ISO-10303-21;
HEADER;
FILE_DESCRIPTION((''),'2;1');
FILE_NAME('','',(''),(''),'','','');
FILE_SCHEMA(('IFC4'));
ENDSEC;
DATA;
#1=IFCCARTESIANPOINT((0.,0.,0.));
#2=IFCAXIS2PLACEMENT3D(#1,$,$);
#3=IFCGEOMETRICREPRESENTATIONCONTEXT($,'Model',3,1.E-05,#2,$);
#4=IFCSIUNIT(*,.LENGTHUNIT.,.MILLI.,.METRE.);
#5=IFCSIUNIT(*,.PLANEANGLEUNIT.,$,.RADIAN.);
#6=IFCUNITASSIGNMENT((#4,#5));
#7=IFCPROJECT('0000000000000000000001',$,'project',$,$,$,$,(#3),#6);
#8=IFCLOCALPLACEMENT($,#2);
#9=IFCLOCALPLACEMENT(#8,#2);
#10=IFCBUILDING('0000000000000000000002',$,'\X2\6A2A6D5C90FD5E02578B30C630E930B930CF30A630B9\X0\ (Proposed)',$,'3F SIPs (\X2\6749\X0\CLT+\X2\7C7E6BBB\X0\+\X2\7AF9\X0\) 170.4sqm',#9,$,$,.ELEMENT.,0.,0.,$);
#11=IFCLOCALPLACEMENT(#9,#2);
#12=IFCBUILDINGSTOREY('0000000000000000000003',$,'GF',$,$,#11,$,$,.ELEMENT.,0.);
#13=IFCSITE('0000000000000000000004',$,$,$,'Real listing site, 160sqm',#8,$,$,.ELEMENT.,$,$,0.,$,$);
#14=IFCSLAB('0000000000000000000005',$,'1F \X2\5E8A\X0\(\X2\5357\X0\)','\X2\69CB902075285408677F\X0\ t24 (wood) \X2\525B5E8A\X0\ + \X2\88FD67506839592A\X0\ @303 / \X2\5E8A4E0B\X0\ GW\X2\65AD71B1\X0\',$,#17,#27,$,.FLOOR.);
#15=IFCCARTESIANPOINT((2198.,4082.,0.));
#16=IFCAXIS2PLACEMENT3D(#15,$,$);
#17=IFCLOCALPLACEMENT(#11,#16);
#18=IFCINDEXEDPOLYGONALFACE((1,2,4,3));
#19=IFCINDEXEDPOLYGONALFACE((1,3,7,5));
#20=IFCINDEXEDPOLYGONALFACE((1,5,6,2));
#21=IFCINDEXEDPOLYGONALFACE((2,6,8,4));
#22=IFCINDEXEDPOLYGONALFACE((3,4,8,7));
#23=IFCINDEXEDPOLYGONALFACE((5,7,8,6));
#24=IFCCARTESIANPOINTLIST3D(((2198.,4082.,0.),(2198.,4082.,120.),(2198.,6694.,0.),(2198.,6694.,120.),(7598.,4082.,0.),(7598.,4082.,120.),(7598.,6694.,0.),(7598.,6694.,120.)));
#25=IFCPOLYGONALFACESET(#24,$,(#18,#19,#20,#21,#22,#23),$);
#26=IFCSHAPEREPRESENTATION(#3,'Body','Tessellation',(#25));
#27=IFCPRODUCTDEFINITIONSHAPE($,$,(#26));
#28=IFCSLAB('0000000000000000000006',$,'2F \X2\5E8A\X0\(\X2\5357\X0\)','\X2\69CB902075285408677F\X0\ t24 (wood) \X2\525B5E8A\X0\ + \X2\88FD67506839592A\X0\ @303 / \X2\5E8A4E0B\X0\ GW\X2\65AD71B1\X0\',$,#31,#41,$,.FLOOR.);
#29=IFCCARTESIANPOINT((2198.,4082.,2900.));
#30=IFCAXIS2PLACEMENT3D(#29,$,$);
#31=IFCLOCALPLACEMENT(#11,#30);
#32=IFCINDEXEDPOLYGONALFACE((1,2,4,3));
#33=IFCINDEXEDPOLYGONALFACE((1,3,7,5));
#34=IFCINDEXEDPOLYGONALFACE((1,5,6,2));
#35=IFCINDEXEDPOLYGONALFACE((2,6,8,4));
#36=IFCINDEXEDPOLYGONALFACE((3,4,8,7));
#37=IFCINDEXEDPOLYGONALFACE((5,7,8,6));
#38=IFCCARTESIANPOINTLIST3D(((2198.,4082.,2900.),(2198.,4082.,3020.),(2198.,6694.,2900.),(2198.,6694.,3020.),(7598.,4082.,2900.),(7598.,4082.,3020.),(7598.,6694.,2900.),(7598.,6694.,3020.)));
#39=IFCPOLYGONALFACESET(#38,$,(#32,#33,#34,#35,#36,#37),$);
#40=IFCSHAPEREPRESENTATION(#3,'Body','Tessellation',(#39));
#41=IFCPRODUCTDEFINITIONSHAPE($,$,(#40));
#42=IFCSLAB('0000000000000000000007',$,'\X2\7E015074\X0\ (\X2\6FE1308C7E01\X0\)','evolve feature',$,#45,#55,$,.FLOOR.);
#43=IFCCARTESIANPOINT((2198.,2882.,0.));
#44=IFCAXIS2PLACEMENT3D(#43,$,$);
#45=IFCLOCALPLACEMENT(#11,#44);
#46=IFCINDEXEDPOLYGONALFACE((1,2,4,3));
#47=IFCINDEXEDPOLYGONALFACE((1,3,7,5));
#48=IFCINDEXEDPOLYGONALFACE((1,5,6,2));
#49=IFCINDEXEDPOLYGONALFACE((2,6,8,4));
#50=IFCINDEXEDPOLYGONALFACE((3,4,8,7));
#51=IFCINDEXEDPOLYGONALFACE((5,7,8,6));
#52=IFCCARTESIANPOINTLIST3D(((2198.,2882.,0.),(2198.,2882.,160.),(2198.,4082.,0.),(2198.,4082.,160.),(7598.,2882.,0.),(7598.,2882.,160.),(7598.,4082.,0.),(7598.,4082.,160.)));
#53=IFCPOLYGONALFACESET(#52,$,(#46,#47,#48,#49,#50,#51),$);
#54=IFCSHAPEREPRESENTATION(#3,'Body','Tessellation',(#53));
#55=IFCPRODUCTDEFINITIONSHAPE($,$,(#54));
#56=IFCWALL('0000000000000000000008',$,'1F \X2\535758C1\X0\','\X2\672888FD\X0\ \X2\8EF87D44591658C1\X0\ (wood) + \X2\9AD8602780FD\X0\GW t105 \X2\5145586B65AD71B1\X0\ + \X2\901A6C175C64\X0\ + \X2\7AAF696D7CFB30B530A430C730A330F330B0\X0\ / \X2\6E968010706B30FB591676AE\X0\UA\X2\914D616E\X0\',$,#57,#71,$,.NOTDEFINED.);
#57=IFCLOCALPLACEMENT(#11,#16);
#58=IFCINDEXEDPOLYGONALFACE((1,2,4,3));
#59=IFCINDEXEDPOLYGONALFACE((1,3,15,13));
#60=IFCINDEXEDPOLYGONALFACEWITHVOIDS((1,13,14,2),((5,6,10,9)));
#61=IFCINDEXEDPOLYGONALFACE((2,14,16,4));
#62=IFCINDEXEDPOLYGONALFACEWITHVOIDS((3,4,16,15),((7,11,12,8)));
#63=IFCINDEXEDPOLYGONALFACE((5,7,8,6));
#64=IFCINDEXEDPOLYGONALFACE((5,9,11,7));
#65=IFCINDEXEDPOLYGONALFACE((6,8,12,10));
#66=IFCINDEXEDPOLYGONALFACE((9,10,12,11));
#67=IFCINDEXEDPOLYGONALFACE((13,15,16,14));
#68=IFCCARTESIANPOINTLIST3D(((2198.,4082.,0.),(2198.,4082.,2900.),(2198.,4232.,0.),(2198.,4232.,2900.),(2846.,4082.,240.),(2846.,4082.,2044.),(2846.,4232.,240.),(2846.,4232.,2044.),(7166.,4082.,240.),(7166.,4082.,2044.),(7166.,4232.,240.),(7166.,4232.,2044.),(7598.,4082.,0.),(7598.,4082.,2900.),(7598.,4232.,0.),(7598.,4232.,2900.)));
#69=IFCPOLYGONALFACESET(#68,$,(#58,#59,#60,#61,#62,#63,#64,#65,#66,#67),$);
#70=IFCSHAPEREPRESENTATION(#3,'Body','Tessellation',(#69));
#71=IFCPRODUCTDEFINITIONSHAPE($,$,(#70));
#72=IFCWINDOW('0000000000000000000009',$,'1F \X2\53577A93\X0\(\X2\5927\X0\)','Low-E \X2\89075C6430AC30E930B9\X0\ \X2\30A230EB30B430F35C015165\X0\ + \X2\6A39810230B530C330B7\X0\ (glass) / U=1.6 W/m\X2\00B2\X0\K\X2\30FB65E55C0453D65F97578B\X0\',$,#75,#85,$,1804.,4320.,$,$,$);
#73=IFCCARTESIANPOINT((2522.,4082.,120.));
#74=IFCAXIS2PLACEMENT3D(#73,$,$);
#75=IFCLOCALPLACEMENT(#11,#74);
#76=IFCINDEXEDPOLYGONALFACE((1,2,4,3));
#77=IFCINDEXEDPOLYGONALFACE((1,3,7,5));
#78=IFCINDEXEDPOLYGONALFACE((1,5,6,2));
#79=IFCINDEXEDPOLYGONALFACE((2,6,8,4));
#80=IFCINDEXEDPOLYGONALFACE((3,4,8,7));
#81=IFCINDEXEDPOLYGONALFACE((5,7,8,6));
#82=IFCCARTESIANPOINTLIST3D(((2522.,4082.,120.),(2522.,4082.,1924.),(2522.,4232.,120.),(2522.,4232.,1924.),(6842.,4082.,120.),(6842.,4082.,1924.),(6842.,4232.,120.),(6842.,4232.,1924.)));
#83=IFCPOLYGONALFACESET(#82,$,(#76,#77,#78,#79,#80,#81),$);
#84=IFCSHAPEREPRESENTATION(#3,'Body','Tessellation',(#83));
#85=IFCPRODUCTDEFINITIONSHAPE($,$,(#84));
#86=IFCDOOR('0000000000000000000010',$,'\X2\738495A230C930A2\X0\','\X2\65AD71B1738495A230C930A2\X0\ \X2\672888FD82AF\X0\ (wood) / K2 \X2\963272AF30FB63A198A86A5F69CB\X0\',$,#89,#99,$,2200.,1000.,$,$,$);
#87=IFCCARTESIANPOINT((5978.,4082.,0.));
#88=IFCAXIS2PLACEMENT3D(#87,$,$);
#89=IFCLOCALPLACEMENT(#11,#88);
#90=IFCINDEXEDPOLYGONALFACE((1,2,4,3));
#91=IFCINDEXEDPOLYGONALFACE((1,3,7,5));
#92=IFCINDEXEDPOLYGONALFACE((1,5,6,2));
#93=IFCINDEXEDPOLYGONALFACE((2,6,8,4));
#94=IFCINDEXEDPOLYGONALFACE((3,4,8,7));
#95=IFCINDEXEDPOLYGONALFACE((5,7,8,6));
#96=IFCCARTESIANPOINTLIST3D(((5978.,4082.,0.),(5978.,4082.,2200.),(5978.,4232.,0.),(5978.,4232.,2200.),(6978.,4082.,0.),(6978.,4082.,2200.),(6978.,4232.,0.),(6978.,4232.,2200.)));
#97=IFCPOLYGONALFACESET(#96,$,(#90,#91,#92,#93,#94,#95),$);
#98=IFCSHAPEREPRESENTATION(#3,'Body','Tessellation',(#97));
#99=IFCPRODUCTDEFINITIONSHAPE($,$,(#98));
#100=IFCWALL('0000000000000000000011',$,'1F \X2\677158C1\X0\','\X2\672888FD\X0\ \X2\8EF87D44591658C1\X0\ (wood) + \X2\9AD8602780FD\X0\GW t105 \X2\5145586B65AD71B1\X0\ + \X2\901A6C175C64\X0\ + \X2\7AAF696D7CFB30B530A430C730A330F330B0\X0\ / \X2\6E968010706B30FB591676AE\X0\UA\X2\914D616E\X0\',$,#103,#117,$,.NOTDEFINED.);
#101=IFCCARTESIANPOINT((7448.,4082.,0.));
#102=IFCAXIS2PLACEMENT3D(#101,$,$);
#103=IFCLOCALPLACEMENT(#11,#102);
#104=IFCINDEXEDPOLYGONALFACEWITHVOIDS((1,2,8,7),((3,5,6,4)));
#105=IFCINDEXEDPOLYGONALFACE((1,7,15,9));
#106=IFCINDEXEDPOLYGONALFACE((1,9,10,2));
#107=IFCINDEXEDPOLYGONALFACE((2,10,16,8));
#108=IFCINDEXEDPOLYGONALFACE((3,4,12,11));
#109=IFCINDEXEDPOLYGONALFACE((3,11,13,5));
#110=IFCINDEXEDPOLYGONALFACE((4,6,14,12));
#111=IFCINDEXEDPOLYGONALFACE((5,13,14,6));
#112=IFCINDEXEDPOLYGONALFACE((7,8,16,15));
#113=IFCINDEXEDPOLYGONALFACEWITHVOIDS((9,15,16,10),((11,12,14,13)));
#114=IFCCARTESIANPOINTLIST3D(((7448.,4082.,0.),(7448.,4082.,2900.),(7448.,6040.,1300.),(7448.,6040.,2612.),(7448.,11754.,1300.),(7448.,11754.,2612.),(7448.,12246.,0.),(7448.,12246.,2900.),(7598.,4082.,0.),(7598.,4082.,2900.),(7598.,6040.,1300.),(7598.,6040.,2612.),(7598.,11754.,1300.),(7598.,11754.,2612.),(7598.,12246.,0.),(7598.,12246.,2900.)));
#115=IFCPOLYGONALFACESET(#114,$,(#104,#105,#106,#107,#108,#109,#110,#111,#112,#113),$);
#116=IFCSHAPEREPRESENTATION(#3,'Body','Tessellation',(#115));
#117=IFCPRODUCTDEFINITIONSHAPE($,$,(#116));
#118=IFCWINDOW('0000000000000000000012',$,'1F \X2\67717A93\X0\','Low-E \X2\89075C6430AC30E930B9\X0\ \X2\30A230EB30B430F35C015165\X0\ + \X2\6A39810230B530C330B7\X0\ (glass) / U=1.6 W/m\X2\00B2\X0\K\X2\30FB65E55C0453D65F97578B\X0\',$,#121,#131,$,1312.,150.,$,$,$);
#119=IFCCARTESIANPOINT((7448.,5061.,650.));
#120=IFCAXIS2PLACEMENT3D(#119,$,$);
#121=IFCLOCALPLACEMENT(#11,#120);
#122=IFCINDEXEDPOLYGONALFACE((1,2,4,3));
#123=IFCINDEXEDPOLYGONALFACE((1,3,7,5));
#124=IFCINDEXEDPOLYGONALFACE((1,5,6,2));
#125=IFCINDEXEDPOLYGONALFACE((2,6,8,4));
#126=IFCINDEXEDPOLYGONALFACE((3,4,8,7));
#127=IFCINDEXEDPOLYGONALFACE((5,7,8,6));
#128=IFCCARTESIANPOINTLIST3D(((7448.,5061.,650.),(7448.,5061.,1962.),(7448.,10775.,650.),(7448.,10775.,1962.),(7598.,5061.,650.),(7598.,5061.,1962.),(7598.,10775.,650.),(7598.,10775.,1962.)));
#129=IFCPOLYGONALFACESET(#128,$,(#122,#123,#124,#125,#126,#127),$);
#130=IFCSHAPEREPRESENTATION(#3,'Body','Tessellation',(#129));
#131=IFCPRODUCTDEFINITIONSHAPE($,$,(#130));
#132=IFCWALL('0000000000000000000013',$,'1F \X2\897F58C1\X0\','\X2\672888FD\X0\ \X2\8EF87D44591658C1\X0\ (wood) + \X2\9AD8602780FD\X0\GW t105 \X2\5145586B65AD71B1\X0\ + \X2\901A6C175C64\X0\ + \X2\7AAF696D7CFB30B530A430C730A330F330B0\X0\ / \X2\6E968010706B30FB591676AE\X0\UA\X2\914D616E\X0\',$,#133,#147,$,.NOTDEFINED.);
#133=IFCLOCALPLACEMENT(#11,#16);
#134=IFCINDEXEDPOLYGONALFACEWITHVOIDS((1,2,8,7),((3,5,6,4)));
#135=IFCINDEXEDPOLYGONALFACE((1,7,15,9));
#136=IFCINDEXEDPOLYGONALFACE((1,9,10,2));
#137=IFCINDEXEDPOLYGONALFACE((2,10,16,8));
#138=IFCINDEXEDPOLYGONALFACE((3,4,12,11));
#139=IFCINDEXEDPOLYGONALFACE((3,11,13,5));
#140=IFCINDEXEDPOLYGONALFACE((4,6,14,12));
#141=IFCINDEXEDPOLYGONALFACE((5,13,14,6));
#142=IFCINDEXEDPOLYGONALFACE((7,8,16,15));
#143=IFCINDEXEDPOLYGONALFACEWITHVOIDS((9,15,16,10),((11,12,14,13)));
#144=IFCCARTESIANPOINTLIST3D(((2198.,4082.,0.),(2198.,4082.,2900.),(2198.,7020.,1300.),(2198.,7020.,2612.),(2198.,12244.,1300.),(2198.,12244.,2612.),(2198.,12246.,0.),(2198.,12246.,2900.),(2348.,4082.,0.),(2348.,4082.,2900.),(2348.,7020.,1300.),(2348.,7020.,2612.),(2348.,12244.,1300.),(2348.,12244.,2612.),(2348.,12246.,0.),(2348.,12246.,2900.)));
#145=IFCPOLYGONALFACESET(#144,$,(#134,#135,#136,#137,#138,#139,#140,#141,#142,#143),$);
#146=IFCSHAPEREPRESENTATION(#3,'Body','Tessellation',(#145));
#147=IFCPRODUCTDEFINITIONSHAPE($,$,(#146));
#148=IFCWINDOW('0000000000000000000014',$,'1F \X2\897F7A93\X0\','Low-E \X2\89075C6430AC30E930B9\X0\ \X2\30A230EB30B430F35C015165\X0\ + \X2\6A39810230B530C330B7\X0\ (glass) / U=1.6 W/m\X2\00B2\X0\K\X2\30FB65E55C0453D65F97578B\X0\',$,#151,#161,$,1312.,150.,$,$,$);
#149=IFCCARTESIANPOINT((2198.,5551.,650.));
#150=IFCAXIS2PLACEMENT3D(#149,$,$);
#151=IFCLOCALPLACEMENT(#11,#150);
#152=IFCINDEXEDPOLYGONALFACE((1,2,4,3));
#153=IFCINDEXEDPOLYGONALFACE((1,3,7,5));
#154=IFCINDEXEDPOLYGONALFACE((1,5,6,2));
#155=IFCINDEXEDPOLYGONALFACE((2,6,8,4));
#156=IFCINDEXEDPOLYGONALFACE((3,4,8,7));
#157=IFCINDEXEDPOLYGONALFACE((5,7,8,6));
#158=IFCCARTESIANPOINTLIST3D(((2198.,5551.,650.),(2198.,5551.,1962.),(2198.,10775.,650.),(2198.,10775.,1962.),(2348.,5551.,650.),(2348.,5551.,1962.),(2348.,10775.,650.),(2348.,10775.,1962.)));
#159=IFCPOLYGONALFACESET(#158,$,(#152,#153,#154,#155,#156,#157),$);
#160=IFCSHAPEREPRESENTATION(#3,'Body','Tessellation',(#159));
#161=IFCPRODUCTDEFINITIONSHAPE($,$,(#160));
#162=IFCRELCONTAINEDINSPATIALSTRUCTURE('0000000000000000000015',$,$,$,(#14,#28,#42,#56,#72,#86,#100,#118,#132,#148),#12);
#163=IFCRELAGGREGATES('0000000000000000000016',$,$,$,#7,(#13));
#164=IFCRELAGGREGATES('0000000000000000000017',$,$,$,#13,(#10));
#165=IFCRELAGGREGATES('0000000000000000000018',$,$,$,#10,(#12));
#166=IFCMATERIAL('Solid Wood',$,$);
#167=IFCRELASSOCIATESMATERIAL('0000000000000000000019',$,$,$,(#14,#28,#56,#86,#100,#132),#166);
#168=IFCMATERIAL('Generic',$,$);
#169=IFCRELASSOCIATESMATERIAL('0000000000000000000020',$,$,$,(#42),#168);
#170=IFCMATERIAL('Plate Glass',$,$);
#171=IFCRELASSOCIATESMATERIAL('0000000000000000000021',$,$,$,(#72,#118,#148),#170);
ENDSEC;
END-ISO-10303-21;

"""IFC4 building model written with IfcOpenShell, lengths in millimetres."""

from ifc_helpers import new_model, si_unit, frame, frame_2d, origin, place, context, project, spatial, rectangle, extrude, material, element, fill, save


model = new_model("IFC4")

# Units and contexts
model_context = context("Model", 3, precision=1e-05, world=origin())
ifc_project = project(units=[si_unit("LENGTHUNIT", "METRE", prefix="MILLI"), si_unit("PLANEANGLEUNIT", "RADIAN")], contexts=[model_context])

# Site, building, storey
site_placement = place(None, origin())
site = spatial("IfcSite", under=ifc_project, at=site_placement, ObjectType="Real listing site, 160sqm", CompositionType="ELEMENT", RefElevation=0.0)
building_placement = place(site_placement, origin())
building = spatial("IfcBuilding", under=site, at=building_placement, Name="横浜都市型テラスハウス (Proposed)", ObjectType="3F SIPs (杉CLT+籾殻+竹) 170.4sqm", CompositionType="ELEMENT", ElevationOfRefHeight=0.0, ElevationOfTerrain=0.0)
storey_placement = place(building_placement, origin())
storey = spatial("IfcBuildingStorey", under=building, at=storey_placement, Name="GF", CompositionType="ELEMENT", Elevation=0.0)

# Slabs
ifc_material_1 = material(Name="Solid Wood")
slab_1_placement = place(storey_placement, frame((2198.0, 4082.0, 0.0)))
element("IfcSlab", 1, at=slab_1_placement, inside=storey, material=ifc_material_1, Name="1F 床(南)", Description="構造用合板 t24 (wood) 剛床 + 製材根太 @303 / 床下 GW断熱", PredefinedType="FLOOR", context=model_context, shape_type="SweptSolid", body=[
    extrude(rectangle(XDim=5400.0, YDim=2612.0, at=frame_2d((2700.0, 1306.0))), frame((2198.0, 4082.0, 0.0)), (0.0, 0.0, 1.0), 120.0),
])
slab_2_placement = place(storey_placement, frame((2198.0, 4082.0, 2900.0)))
element("IfcSlab", 2, at=slab_2_placement, inside=storey, material=ifc_material_1, Name="2F 床(南)", Description="構造用合板 t24 (wood) 剛床 + 製材根太 @303 / 床下 GW断熱", PredefinedType="FLOOR", context=model_context, shape_type="SweptSolid", body=[
    extrude(rectangle(XDim=5400.0, YDim=2612.0, at=frame_2d((2700.0, 1306.0))), frame((2198.0, 4082.0, 2900.0)), (0.0, 0.0, 1.0), 120.0),
])
ifc_material_2 = material(Name="Generic")
slab_3_placement = place(storey_placement, frame((2198.0, 2882.0, 0.0)))
element("IfcSlab", 3, at=slab_3_placement, inside=storey, material=ifc_material_2, Name="縁側 (濡れ縁)", Description="evolve feature", PredefinedType="FLOOR", context=model_context, shape_type="SweptSolid", body=[
    extrude(rectangle(XDim=5400.0, YDim=1200.0, at=frame_2d((2700.0, 600.0))), frame((2198.0, 2882.0, 0.0)), (0.0, 0.0, 1.0), 160.0),
])

# Wall, openings, window, door
wall_1_placement = place(storey_placement, frame((2198.0, 4082.0, 0.0)))
wall_1 = element("IfcWall", 4, at=wall_1_placement, inside=storey, material=ifc_material_1, Name="1F 南壁", Description="木製 軸組外壁 (wood) + 高性能GW t105 充填断熱 + 通気層 + 窯業系サイディング / 準耐火・外皮UA配慮", PredefinedType="NOTDEFINED", context=model_context, shape_type="SweptSolid", body=[
    extrude(rectangle(XDim=5400.0, YDim=150.0, at=frame_2d((2700.0, 75.0))), frame((2198.0, 4082.0, 0.0)), (0.0, 0.0, 1.0), 2900.0),
])
opening_1_placement = place(storey_placement, frame((2522.0, 4082.0, 120.0)))
opening_1 = element("IfcOpeningElement", 5, at=opening_1_placement, cuts=wall_1, PredefinedType="NOTDEFINED", context=model_context, shape_type="SweptSolid", body=[
    extrude(rectangle(XDim=4320.0, YDim=150.0, at=frame_2d((2160.0, 75.0))), frame((2522.0, 4082.0, 120.0)), (0.0, 0.0, 1.0), 1804.0),
])
opening_2_placement = place(storey_placement, frame((5978.0, 4082.0, 0.0)))
opening_2 = element("IfcOpeningElement", 6, at=opening_2_placement, cuts=wall_1, PredefinedType="NOTDEFINED", context=model_context, shape_type="SweptSolid", body=[
    extrude(rectangle(XDim=1000.0, YDim=150.0, at=frame_2d((500.0, 75.0))), frame((5978.0, 4082.0, 0.0)), (0.0, 0.0, 1.0), 2200.0),
])
ifc_material_3 = material(Name="Plate Glass")
window_1_placement = place(storey_placement, frame((2522.0, 4082.0, 120.0)))
window_1 = element("IfcWindow", 7, at=window_1_placement, inside=storey, material=ifc_material_3, Name="1F 南窓(大)", Description="Low-E 複層ガラス アルゴン封入 + 樹脂サッシ (glass) / U=1.6 W/m²K・日射取得型", OverallHeight=1804.0, OverallWidth=4320.0, context=model_context, shape_type="SweptSolid", body=[
    extrude(rectangle(XDim=4320.0, YDim=150.0, at=frame_2d((2160.0, 75.0))), frame((2522.0, 4082.0, 120.0)), (0.0, 0.0, 1.0), 1804.0),
])
fill(opening_1, window_1)
door_placement = place(storey_placement, frame((5978.0, 4082.0, 0.0)))
door = element("IfcDoor", 8, at=door_placement, inside=storey, material=ifc_material_1, Name="玄関ドア", Description="断熱玄関ドア 木製芯 (wood) / K2 防犯・採風機構", OverallHeight=2200.0, OverallWidth=1000.0, context=model_context, shape_type="SweptSolid", body=[
    extrude(rectangle(XDim=1000.0, YDim=150.0, at=frame_2d((500.0, 75.0))), frame((5978.0, 4082.0, 0.0)), (0.0, 0.0, 1.0), 2200.0),
])
fill(opening_2, door)

# Walls, openings, windows
wall_2_placement = place(storey_placement, frame((7448.0, 4082.0, 0.0)))
wall_2 = element("IfcWall", 9, at=wall_2_placement, inside=storey, material=ifc_material_1, Name="1F 東壁", Description="木製 軸組外壁 (wood) + 高性能GW t105 充填断熱 + 通気層 + 窯業系サイディング / 準耐火・外皮UA配慮", PredefinedType="NOTDEFINED", context=model_context, shape_type="SweptSolid", body=[
    extrude(rectangle(XDim=150.0, YDim=8164.0, at=frame_2d((75.0, 4082.0))), frame((7448.0, 4082.0, 0.0)), (0.0, 0.0, 1.0), 2900.0),
])
opening_3_placement = place(storey_placement, frame((7448.0, 5061.0, 650.0)))
opening_3 = element("IfcOpeningElement", 10, at=opening_3_placement, cuts=wall_2, PredefinedType="NOTDEFINED", context=model_context, shape_type="SweptSolid", body=[
    extrude(rectangle(XDim=150.0, YDim=5714.0, at=frame_2d((75.0, 2857.0))), frame((7448.0, 5061.0, 650.0)), (0.0, 0.0, 1.0), 1312.0),
])
window_2_placement = place(storey_placement, frame((7448.0, 5061.0, 650.0)))
window_2 = element("IfcWindow", 11, at=window_2_placement, inside=storey, material=ifc_material_3, Name="1F 東窓", Description="Low-E 複層ガラス アルゴン封入 + 樹脂サッシ (glass) / U=1.6 W/m²K・日射取得型", OverallHeight=1312.0, OverallWidth=150.0, context=model_context, shape_type="SweptSolid", body=[
    extrude(rectangle(XDim=150.0, YDim=5714.0, at=frame_2d((75.0, 2857.0))), frame((7448.0, 5061.0, 650.0)), (0.0, 0.0, 1.0), 1312.0),
])
fill(opening_3, window_2)
wall_3_placement = place(storey_placement, frame((2198.0, 4082.0, 0.0)))
wall_3 = element("IfcWall", 12, at=wall_3_placement, inside=storey, material=ifc_material_1, Name="1F 西壁", Description="木製 軸組外壁 (wood) + 高性能GW t105 充填断熱 + 通気層 + 窯業系サイディング / 準耐火・外皮UA配慮", PredefinedType="NOTDEFINED", context=model_context, shape_type="SweptSolid", body=[
    extrude(rectangle(XDim=150.0, YDim=8164.0, at=frame_2d((75.0, 4082.0))), frame((2198.0, 4082.0, 0.0)), (0.0, 0.0, 1.0), 2900.0),
])
opening_4_placement = place(storey_placement, frame((2198.0, 5551.0, 650.0)))
opening_4 = element("IfcOpeningElement", 13, at=opening_4_placement, cuts=wall_3, PredefinedType="NOTDEFINED", context=model_context, shape_type="SweptSolid", body=[
    extrude(rectangle(XDim=150.0, YDim=5224.0, at=frame_2d((75.0, 2612.0))), frame((2198.0, 5551.0, 650.0)), (0.0, 0.0, 1.0), 1312.0),
])
window_3_placement = place(storey_placement, frame((2198.0, 5551.0, 650.0)))
window_3 = element("IfcWindow", 14, at=window_3_placement, inside=storey, material=ifc_material_3, Name="1F 西窓", Description="Low-E 複層ガラス アルゴン封入 + 樹脂サッシ (glass) / U=1.6 W/m²K・日射取得型", OverallHeight=1312.0, OverallWidth=150.0, context=model_context, shape_type="SweptSolid", body=[
    extrude(rectangle(XDim=150.0, YDim=5224.0, at=frame_2d((75.0, 2612.0))), frame((2198.0, 5551.0, 650.0)), (0.0, 0.0, 1.0), 1312.0),
])
fill(opening_4, window_3)

save(model, "model.ifc")
